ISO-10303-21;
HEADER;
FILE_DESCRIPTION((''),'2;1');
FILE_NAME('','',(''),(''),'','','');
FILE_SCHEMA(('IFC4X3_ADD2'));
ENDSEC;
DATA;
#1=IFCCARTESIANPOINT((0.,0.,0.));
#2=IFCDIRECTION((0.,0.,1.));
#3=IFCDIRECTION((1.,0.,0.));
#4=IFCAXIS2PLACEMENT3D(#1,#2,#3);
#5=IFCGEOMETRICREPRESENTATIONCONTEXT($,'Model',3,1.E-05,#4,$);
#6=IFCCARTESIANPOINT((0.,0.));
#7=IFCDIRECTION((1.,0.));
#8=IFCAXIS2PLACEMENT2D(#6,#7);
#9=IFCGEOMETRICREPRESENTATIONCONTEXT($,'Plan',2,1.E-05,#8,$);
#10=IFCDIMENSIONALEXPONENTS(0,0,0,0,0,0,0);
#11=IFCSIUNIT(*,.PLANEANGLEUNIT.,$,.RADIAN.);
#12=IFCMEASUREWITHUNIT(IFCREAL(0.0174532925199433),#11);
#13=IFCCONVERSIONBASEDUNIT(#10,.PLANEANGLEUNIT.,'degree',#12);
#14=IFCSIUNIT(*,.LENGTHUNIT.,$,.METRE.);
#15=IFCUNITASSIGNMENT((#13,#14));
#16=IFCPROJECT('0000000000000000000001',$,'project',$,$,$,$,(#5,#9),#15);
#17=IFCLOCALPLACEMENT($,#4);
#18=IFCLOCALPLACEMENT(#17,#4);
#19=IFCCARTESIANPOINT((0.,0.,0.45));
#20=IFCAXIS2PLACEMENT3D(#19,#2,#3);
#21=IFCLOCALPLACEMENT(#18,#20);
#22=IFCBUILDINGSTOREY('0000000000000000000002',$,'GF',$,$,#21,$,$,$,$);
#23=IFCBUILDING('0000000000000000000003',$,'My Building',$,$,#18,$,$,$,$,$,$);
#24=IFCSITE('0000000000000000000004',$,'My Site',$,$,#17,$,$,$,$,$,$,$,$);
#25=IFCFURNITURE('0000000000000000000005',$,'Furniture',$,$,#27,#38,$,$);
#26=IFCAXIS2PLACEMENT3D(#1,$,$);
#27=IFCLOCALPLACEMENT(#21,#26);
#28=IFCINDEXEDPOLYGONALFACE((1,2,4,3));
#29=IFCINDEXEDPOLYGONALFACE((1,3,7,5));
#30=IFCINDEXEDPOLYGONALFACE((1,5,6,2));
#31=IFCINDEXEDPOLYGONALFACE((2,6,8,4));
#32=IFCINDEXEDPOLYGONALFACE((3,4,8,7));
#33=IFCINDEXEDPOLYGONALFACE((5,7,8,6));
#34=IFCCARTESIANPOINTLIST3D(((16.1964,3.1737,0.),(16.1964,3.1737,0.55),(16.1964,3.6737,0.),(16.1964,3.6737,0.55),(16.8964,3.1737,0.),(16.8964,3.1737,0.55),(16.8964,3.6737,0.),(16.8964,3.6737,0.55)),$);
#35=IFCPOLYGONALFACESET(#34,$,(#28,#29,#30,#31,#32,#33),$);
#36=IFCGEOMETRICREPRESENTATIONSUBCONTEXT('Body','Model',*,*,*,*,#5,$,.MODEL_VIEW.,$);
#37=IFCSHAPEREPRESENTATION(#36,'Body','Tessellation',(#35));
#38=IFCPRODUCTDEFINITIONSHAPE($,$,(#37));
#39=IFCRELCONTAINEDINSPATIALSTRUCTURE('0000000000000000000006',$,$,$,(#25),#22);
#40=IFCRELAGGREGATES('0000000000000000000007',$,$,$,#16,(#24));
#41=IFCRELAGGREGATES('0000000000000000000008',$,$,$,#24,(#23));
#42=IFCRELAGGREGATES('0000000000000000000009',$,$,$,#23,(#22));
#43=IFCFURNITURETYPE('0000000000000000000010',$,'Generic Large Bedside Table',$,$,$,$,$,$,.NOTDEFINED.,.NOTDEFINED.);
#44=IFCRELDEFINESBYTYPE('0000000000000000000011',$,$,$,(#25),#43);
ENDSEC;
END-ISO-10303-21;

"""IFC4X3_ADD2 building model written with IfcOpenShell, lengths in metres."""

from ifc_helpers import new_model, entity, si_unit, converted_unit, frame, origin_with_axes, origin_2d_with_axis, place, context, subcontext, project, spatial, line, indexed_curve, outline, extrude, shape, source, transform, mapped, type_object, type_shapes, element, save


model = new_model("IFC4X3_ADD2")

# Units and contexts
model_context = context("Model", 3, precision=1e-05, world=origin_with_axes())
plan_context = context("Plan", 2, precision=1e-05, world=origin_2d_with_axis())
body_context_1 = subcontext(model_context, "Body", "Model", "MODEL_VIEW")
body_context_2 = subcontext(plan_context, "Body", "Plan", "PLAN_VIEW")
ifc_project = project(units=[converted_unit("PLANEANGLEUNIT", "degree", entity("IfcReal", 0.0174532925199433), si_unit("PLANEANGLEUNIT", "RADIAN"), dimensions=[0, 0, 0, 0, 0, 0, 0]), si_unit("LENGTHUNIT", "METRE")], contexts=[model_context, plan_context])

# Site, building, storey
site_placement = place(None, origin_with_axes())
site = spatial("IfcSite", under=ifc_project, at=site_placement, Name="My Site")
building_placement = place(site_placement, origin_with_axes())
building = spatial("IfcBuilding", under=site, at=building_placement, Name="My Building")
storey_placement = place(building_placement, frame((0.0, 0.0, 0.45), z_axis=(0.0, 0.0, 1.0), x_axis=(1.0, 0.0, 0.0)))
storey = spatial("IfcBuildingStorey", under=building, at=storey_placement, Name="GF")

# Furniture
furniture_type_1 = type_object("IfcFurnitureType", Name="Generic Large Bedside Table", AssemblyPlace="NOTDEFINED", PredefinedType="NOTDEFINED")
shared_shape_1 = source(origin_with_axes(), body_context_1, "Body", "SweptSolid", [
    extrude(outline(indexed_curve([(0.0, 0.0), (0.7, 0.0), (0.7, 0.5), (0.0, 0.5)], segments=[line(1, 2, 3, 4, 1)])), frame((-0.35, -0.25, 0.0), z_axis=(0.0, 0.0, 1.0), x_axis=(1.0, 0.0, 0.0)), (0.0, 0.0, 1.0), 0.55),
])
shared_shape_2 = source(origin_with_axes(), body_context_2, "Body", "Curve2D", [
    entity("IfcIndexedPolyCurve", entity("IfcCartesianPointList2D", [[-0.35, -0.25], [0.35, -0.25], [0.35, 0.25], [-0.35, 0.25]]), [entity("IfcLineIndex", [1, 2, 3, 4, 1])]),
])
type_shapes(furniture_type_1, [shared_shape_1, shared_shape_2])
for number, where, z_axis, x_axis, name in (
    (1, (16.5464, 3.4237, 0.0), (0.0, 0.0, 1.0), (1.0, 0.0, 0.0), "Furniture"),
):
    element("IfcFurniture", number, at=place(storey_placement, frame(where, z_axis=z_axis, x_axis=x_axis)), inside=storey, type_object=furniture_type_1, Name=name, shapes=[
        shape(body_context_1, "Body", "MappedRepresentation", [mapped(shared_shape_1, transform((0.0, 0.0, 0.0), x_axis=(1.0, 0.0, 0.0), y_axis=(0.0, 1.0, 0.0), z_axis=(0.0, 0.0, 1.0), scale=1.0))]),
        shape(body_context_2, "Body", "MappedRepresentation", [mapped(shared_shape_2, transform((0.0, 0.0, 0.0), x_axis=(1.0, 0.0, 0.0), y_axis=(0.0, 1.0, 0.0), z_axis=(0.0, 0.0, 1.0), scale=1.0))]),
    ])

save(model, "model.ifc")
